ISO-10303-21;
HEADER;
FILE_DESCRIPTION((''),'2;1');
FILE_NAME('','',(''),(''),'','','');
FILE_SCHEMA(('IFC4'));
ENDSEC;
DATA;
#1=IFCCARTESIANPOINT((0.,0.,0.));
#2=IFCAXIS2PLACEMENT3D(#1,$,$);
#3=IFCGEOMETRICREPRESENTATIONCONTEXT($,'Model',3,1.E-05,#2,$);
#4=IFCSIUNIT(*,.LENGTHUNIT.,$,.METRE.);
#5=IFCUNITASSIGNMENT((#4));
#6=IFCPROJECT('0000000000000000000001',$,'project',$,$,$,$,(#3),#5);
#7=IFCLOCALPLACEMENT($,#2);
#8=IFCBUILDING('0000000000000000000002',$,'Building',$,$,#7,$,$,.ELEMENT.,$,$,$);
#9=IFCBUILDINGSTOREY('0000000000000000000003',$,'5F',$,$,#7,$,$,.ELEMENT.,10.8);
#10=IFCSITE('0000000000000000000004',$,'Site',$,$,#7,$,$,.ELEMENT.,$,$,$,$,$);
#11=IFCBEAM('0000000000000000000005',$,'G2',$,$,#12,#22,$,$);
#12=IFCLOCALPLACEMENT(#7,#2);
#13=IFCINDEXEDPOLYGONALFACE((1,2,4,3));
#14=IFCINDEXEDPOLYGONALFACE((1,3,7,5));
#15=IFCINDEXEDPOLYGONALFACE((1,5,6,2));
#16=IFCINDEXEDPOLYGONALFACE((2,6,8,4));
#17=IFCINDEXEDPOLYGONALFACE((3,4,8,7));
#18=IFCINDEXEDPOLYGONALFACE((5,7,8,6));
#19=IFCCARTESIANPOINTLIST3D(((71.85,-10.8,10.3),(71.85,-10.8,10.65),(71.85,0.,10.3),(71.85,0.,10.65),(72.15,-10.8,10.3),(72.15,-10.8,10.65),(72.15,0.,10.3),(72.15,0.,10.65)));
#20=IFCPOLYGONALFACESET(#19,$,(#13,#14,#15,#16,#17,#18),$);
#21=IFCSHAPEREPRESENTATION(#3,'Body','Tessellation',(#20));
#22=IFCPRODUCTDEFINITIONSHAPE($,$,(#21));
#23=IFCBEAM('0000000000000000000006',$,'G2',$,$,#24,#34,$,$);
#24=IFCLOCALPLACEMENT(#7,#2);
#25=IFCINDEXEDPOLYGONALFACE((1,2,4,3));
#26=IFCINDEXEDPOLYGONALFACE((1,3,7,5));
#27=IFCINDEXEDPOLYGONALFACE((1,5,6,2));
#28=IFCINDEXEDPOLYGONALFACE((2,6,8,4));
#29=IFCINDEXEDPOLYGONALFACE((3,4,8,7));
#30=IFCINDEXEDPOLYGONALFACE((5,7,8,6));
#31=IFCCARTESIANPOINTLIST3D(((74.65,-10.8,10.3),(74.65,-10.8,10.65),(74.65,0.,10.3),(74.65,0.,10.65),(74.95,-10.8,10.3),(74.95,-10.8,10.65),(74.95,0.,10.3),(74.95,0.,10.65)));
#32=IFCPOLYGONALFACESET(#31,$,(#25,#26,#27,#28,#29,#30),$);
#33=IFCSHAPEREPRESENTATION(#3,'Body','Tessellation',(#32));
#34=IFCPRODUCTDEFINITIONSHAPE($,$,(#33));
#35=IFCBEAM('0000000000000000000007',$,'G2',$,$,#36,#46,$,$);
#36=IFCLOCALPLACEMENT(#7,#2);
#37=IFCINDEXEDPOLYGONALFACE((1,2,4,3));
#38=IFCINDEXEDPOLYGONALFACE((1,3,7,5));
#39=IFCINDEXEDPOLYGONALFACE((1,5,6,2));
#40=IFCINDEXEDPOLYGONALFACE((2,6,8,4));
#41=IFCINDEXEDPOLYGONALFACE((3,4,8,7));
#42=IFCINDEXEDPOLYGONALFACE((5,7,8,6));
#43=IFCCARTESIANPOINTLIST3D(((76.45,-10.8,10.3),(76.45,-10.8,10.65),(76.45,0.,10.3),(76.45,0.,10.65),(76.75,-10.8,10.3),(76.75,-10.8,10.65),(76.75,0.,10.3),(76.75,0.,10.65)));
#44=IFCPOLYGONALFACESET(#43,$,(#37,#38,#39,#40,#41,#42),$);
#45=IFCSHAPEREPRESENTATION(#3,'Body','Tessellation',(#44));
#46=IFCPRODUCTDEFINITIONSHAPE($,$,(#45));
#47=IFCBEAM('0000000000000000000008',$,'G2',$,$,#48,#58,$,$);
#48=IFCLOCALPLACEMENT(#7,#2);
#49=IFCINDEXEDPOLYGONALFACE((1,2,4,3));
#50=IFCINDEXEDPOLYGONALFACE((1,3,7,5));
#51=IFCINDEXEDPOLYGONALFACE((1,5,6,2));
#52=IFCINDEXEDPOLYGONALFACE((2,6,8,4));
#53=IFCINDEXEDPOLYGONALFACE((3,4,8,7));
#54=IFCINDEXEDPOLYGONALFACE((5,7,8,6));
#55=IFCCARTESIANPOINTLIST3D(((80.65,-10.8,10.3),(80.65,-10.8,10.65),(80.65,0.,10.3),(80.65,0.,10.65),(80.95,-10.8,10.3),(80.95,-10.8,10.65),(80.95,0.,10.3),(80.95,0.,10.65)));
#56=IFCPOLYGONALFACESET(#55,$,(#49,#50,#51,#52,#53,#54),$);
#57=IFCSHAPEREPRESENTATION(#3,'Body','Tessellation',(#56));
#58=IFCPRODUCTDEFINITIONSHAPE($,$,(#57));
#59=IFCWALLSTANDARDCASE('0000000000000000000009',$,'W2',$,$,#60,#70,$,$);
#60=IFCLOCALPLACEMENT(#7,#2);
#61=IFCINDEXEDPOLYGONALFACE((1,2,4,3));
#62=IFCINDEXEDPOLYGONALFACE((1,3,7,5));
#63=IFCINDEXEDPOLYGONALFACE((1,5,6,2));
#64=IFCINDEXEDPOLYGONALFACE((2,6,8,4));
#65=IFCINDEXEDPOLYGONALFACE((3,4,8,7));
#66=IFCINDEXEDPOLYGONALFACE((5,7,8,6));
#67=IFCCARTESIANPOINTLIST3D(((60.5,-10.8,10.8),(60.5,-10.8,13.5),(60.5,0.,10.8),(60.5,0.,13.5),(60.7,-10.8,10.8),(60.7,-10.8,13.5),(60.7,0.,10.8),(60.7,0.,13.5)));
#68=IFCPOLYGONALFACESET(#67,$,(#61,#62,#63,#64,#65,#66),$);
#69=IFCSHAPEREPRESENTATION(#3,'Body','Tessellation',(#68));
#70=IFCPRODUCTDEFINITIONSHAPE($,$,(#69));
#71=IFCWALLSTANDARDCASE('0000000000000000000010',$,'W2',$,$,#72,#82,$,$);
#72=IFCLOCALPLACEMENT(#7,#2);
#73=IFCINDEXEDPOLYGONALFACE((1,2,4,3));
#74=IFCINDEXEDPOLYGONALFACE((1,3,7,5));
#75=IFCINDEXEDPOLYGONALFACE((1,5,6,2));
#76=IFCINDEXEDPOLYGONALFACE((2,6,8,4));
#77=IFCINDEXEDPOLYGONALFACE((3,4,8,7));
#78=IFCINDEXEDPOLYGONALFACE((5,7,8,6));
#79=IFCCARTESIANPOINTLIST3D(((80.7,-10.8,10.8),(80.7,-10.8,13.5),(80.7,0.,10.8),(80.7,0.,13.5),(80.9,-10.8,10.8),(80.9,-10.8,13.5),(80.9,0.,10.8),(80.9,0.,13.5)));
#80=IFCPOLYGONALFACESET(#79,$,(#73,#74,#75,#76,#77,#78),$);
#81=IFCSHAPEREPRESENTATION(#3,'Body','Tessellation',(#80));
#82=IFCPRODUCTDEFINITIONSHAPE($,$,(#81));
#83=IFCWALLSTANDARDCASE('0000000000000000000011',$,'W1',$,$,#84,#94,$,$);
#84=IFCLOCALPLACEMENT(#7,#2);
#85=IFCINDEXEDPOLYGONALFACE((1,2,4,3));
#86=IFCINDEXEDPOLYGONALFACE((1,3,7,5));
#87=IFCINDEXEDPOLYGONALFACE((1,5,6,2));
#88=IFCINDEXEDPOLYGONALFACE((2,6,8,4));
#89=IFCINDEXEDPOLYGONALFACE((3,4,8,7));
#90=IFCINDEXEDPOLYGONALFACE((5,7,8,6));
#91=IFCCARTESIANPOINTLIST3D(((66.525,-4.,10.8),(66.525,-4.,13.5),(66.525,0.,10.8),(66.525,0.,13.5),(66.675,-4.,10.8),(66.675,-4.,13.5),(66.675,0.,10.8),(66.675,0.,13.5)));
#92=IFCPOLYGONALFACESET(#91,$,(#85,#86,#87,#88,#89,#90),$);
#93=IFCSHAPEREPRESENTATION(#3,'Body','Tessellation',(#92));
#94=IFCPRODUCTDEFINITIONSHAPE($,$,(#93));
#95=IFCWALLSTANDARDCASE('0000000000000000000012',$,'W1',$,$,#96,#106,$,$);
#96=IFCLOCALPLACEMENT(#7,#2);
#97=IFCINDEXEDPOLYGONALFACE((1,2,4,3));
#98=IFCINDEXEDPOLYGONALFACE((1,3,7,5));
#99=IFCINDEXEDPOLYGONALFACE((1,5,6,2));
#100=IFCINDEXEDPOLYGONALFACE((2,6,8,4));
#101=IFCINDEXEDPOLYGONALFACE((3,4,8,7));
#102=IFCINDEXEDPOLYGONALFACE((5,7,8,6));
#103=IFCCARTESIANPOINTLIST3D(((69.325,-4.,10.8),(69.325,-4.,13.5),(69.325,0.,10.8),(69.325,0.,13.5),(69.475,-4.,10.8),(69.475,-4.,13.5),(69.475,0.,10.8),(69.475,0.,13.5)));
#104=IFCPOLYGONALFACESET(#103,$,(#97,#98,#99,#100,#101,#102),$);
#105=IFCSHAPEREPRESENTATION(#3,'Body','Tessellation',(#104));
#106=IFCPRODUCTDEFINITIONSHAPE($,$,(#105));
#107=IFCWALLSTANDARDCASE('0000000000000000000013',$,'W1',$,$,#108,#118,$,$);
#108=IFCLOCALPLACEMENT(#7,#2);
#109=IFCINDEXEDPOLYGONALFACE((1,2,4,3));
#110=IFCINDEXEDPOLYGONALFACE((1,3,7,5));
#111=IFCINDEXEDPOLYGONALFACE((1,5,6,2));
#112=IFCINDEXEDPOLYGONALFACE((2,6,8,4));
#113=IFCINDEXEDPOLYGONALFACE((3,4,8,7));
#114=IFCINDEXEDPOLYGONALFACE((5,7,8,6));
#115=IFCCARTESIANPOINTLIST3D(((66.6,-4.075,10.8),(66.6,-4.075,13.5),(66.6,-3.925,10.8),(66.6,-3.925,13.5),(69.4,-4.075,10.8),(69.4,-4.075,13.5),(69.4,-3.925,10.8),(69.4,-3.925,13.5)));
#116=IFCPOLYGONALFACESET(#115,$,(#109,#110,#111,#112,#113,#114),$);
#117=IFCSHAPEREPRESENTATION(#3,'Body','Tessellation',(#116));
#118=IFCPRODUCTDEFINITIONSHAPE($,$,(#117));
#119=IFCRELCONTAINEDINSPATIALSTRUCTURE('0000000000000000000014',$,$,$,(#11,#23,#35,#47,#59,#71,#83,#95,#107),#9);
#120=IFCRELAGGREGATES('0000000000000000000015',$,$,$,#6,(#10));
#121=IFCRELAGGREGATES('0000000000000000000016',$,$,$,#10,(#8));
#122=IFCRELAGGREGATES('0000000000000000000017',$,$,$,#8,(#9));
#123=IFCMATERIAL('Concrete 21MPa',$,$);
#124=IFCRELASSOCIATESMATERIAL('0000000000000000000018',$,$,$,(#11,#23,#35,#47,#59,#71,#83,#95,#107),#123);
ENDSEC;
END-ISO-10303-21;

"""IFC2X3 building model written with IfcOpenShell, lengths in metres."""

from ifc_helpers import new_model, si_unit, frame, origin, origin_2d, place, context, project, spatial, rectangle, extrude, material, element, save


model = new_model("IFC2X3")

# Units and contexts
model_context = context("Model", 3, precision=1e-05, world=origin())
ifc_project = project(units=[si_unit("LENGTHUNIT", "METRE")], contexts=[model_context])

# Site, building, storey
placement = place(None, origin())
site = spatial("IfcSite", under=ifc_project, at=placement, Name="Site", CompositionType="ELEMENT")
building = spatial("IfcBuilding", under=site, at=placement, Name="Building", CompositionType="ELEMENT")
storey = spatial("IfcBuildingStorey", under=building, at=placement, Name="5F", CompositionType="ELEMENT", Elevation=10.8)

# Shared definitions
ifc_material = material(Name="Concrete 21MPa")

# Beams
for number, where, name in (
    (1, (72.0, -5.4, 10.3), "G2"),
    (2, (74.8, -5.4, 10.3), "G2"),
    (3, (76.6, -5.4, 10.3), "G2"),
    (4, (80.8, -5.4, 10.3), "G2"),
):
    element("IfcBeam", number, at=place(None, frame(where)), inside=storey, material=ifc_material, Name=name, context=model_context, shape_type="SweptSolid", body=[
        extrude(rectangle(XDim=0.3, YDim=10.8, at=origin_2d()), origin(), (0.0, 0.0, 1.0), 0.35),
    ])

# Walls
for number, where, name in (
    (5, (60.6, -5.4, 10.8), "W2"),
    (6, (80.8, -5.4, 10.8), "W2"),
):
    element("IfcWallStandardCase", number, at=place(None, frame(where)), inside=storey, material=ifc_material, Name=name, context=model_context, shape_type="SweptSolid", body=[
        extrude(rectangle(XDim=0.2, YDim=10.8, at=origin_2d()), origin(), (0.0, 0.0, 1.0), 2.7),
    ])
for number, where, name in (
    (7, (66.6, -2.0, 10.8), "W1"),
    (8, (69.4, -2.0, 10.8), "W1"),
):
    element("IfcWallStandardCase", number, at=place(None, frame(where)), inside=storey, material=ifc_material, Name=name, context=model_context, shape_type="SweptSolid", body=[
        extrude(rectangle(XDim=0.15, YDim=4.0, at=origin_2d()), origin(), (0.0, 0.0, 1.0), 2.7),
    ])
wall_placement = place(None, frame((68.0, -4.0, 10.8)))
element("IfcWallStandardCase", 9, at=wall_placement, inside=storey, material=ifc_material, Name="W1", context=model_context, shape_type="SweptSolid", body=[
    extrude(rectangle(XDim=2.8, YDim=0.15, at=origin_2d()), origin(), (0.0, 0.0, 1.0), 2.7),
])

save(model, "model.ifc")
